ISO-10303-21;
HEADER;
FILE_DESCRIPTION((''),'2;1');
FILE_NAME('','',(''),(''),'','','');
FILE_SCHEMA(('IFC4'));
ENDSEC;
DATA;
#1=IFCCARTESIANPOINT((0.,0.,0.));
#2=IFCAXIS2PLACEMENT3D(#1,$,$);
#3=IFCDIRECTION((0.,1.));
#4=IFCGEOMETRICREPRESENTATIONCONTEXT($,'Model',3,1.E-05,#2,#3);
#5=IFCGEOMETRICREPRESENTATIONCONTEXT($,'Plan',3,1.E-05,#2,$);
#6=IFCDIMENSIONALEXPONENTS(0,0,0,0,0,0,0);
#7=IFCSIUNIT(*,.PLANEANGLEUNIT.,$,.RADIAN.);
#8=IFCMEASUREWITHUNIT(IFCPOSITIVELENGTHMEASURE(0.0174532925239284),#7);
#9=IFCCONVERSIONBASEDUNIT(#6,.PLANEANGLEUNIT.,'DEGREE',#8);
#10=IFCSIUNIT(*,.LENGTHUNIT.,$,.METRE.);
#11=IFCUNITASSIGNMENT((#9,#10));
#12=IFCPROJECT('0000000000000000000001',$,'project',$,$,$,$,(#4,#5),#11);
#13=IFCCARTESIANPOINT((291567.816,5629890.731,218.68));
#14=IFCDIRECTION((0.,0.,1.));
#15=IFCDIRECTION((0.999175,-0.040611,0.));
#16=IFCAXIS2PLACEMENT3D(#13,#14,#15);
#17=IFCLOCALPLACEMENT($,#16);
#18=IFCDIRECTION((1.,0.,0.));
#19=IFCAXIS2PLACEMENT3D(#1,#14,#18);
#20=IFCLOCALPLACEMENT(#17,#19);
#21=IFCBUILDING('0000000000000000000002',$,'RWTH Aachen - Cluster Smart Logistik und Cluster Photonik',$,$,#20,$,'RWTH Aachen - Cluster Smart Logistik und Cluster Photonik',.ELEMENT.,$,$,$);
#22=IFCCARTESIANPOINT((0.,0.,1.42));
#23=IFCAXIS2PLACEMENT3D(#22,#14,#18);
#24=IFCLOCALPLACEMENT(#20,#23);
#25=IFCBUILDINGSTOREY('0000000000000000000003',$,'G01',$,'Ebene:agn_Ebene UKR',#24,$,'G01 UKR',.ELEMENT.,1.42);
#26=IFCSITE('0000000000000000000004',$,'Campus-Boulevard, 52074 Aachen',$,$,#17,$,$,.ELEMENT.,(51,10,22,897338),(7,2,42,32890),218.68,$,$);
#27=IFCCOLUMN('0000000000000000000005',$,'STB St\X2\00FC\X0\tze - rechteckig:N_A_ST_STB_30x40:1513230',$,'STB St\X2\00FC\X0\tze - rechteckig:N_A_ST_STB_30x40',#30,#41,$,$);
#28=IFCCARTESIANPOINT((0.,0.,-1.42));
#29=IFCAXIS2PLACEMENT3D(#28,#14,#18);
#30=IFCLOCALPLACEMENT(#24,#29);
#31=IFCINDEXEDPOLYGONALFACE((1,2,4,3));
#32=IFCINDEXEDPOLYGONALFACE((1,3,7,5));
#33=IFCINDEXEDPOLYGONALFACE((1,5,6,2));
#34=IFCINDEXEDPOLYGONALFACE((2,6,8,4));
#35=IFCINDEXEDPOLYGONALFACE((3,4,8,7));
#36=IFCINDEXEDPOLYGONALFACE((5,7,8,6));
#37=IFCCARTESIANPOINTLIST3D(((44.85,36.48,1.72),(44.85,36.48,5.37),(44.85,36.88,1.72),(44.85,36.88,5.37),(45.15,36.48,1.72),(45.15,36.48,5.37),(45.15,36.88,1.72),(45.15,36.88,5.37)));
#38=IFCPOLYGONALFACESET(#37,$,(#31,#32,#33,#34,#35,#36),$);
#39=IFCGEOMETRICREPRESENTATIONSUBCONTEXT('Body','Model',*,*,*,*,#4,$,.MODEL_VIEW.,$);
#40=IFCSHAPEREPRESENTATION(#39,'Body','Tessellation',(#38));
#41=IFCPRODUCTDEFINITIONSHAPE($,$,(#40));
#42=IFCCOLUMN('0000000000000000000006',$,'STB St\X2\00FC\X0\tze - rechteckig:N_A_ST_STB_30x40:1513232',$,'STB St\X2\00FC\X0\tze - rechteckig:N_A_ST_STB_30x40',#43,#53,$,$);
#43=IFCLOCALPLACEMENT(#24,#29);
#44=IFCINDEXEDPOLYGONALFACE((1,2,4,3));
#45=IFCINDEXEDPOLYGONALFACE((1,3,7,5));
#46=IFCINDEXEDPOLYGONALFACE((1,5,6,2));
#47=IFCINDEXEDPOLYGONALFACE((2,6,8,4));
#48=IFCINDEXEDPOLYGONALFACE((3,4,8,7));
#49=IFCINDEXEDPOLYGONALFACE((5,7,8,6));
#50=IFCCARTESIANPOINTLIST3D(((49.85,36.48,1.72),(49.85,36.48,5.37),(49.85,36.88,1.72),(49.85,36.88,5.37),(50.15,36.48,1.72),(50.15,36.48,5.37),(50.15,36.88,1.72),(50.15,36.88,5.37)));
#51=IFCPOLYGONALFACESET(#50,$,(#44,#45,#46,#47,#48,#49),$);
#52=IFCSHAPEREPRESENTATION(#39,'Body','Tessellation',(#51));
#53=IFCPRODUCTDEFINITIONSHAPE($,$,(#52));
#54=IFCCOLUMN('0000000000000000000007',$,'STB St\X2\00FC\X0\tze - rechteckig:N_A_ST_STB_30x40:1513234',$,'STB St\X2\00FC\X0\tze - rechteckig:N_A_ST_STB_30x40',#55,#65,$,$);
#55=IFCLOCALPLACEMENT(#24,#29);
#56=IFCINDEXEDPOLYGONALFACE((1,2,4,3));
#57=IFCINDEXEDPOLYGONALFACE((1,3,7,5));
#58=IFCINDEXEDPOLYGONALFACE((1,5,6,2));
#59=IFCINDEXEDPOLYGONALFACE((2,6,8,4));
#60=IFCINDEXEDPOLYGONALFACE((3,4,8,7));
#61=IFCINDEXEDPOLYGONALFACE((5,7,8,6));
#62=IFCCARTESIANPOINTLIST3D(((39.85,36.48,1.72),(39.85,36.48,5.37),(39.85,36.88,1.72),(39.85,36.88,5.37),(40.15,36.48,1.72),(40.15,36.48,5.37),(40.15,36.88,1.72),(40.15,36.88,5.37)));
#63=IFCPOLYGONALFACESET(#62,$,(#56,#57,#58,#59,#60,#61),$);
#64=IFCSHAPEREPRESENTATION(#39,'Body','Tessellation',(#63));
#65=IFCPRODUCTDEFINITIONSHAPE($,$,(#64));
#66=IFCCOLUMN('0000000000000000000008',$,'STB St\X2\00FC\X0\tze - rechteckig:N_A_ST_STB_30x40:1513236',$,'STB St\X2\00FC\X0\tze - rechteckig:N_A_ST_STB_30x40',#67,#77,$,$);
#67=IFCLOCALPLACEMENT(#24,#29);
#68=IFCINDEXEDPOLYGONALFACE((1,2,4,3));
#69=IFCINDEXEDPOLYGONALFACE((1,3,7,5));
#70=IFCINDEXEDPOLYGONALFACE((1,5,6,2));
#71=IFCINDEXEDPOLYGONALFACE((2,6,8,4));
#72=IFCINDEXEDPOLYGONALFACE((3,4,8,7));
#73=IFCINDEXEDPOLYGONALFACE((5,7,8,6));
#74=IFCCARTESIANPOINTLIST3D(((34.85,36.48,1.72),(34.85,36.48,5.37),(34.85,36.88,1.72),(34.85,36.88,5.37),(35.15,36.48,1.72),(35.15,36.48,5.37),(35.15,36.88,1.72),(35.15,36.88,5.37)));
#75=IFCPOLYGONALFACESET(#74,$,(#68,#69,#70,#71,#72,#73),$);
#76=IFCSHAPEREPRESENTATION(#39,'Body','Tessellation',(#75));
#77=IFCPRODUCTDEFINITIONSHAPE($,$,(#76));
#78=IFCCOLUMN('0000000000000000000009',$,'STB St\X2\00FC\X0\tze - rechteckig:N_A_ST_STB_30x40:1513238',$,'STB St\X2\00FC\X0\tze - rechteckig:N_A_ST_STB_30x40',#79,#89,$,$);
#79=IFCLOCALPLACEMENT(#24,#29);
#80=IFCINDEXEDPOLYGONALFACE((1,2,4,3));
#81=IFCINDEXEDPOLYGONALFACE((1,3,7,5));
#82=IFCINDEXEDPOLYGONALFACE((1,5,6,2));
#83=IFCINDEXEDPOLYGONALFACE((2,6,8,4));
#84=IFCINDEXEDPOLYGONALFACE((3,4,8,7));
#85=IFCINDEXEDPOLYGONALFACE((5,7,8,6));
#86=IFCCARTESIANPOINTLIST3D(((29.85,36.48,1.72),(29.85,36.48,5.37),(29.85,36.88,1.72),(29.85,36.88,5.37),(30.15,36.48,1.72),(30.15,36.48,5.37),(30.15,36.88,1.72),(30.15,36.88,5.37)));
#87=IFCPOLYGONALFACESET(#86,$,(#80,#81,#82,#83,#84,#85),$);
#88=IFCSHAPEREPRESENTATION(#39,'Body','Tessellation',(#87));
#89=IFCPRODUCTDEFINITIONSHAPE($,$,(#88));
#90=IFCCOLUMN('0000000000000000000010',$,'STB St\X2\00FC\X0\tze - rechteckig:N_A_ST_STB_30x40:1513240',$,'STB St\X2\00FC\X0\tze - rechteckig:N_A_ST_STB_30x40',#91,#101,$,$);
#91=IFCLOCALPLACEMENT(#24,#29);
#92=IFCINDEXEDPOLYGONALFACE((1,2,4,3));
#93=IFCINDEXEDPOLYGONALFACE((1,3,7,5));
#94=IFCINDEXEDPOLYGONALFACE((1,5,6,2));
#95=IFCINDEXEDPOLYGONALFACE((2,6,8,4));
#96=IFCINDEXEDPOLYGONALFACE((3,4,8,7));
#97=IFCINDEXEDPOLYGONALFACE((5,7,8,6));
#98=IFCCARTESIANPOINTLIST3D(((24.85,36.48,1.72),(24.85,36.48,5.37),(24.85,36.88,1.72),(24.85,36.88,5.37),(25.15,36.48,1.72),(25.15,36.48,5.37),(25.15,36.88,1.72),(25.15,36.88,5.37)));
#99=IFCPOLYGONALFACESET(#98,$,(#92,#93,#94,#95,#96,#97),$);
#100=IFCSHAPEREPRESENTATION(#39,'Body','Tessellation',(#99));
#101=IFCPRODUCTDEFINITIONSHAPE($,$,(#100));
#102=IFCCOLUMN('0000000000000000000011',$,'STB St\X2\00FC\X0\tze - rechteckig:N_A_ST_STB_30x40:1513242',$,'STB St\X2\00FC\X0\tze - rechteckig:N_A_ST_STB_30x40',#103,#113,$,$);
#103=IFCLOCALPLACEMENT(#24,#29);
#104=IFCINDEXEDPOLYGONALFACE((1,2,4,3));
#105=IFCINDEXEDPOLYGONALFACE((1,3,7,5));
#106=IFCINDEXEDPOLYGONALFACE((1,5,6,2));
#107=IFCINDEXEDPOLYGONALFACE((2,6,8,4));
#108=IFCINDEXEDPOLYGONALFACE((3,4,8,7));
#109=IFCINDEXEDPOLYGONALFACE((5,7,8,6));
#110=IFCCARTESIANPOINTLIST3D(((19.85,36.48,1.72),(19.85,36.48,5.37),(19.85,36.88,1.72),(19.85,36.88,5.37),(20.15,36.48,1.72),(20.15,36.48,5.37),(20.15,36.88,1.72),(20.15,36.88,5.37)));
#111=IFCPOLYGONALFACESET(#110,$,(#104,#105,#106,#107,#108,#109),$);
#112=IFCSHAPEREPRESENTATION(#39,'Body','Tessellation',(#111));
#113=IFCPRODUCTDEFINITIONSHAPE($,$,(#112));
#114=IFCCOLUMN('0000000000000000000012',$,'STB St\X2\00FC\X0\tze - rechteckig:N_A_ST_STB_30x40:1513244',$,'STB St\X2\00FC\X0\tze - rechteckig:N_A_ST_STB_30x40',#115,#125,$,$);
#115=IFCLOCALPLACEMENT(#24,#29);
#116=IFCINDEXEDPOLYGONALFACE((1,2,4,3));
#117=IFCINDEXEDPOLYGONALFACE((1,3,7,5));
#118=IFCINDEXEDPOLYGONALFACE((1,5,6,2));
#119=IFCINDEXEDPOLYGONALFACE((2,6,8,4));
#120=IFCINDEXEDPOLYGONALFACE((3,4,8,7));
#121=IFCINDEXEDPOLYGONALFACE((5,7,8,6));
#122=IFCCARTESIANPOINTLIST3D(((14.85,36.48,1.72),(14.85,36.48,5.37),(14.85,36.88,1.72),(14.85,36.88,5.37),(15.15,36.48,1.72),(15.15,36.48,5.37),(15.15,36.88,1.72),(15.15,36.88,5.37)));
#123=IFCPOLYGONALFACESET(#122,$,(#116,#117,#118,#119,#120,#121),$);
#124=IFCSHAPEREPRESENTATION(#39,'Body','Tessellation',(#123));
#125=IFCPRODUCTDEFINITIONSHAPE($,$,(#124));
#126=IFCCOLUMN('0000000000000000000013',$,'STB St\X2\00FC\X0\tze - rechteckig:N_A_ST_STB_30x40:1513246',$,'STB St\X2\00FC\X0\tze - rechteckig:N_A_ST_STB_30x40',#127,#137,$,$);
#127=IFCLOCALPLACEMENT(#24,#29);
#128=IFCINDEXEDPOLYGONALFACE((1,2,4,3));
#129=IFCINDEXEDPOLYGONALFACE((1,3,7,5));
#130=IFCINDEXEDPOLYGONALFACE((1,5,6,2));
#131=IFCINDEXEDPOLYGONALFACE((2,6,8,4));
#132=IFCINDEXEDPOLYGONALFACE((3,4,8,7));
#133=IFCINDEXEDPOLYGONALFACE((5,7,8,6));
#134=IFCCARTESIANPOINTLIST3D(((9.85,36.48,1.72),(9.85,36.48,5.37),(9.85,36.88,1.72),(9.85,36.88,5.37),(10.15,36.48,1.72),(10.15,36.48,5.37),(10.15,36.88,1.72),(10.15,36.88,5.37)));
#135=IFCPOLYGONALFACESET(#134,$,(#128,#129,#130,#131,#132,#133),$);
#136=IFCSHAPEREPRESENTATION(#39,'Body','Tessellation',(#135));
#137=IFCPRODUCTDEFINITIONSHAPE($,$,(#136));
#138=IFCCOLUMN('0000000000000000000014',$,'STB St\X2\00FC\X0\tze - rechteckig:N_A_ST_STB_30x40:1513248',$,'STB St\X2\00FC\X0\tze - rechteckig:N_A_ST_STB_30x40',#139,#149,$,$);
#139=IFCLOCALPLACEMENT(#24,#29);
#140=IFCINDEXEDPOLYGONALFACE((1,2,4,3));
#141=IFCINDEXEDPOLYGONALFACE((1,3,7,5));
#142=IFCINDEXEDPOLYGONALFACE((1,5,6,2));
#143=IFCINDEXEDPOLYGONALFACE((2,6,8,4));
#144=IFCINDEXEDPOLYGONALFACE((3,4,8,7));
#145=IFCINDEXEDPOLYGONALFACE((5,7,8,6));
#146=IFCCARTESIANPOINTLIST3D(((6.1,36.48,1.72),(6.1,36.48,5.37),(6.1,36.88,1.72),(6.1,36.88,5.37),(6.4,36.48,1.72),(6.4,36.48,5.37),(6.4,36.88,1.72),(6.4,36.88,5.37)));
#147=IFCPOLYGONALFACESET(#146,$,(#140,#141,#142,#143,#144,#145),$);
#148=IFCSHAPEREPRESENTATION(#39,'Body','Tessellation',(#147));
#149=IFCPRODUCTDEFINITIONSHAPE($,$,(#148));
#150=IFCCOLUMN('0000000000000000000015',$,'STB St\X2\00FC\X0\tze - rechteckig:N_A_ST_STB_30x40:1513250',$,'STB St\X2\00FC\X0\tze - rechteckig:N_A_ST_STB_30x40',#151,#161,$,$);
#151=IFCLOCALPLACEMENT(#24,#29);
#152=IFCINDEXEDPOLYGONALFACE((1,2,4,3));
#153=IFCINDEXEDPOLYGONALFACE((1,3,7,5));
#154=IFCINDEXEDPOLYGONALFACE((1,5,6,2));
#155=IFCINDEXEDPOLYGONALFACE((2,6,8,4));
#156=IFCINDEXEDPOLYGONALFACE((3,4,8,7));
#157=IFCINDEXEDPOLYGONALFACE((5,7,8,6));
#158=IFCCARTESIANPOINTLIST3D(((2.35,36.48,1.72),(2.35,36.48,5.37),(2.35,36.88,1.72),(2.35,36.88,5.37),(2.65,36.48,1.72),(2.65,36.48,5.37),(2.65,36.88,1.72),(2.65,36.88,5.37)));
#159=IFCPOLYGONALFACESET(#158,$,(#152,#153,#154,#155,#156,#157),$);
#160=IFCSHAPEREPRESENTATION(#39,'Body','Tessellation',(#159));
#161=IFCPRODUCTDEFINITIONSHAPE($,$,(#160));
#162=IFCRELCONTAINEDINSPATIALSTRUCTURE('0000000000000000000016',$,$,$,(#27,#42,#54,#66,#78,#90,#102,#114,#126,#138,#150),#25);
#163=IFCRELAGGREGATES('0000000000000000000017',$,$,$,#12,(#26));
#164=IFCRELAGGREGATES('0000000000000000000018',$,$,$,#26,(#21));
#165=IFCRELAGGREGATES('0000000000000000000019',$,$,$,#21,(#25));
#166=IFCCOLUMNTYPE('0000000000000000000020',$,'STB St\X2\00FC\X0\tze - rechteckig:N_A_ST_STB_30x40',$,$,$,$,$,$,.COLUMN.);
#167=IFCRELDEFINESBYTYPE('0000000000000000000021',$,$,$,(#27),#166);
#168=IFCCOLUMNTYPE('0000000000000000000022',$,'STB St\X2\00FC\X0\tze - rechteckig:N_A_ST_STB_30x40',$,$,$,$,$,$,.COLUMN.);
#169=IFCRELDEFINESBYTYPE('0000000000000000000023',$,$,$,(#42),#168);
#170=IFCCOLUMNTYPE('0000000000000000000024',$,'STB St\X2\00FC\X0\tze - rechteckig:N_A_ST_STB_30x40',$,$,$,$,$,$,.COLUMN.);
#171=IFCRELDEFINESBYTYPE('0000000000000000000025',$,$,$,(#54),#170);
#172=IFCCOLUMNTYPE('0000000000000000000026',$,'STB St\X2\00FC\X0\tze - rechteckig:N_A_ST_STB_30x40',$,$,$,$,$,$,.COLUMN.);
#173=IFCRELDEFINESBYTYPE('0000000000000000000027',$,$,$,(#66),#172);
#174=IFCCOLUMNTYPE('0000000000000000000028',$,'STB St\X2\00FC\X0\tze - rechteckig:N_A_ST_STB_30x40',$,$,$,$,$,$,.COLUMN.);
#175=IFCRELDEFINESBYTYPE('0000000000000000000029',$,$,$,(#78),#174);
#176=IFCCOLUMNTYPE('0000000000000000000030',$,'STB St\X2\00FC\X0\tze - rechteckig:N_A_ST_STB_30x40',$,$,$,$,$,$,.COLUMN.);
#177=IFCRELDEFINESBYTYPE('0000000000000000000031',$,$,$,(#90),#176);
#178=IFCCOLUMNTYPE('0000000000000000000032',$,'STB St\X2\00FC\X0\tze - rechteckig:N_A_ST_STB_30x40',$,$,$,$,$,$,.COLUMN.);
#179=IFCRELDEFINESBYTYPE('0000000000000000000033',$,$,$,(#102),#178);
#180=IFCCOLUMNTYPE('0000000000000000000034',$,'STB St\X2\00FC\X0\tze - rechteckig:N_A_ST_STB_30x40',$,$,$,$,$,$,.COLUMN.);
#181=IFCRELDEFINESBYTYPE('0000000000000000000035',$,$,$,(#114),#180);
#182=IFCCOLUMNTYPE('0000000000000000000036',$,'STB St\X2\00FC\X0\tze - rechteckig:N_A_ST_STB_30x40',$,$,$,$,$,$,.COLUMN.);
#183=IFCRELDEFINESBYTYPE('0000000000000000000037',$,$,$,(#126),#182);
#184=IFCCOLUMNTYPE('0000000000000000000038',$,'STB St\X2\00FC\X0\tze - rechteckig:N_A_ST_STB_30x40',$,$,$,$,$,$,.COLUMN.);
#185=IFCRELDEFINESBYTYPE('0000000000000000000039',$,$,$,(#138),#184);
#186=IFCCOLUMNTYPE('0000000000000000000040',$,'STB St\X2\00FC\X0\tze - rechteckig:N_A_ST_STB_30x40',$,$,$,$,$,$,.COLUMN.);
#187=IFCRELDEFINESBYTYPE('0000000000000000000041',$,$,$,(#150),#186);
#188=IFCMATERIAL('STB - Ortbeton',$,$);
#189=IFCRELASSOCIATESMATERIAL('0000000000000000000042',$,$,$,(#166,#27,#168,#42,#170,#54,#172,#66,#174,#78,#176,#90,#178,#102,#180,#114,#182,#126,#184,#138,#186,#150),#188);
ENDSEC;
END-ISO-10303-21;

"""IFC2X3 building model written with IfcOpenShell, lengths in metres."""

from ifc_helpers import new_model, entity, si_unit, converted_unit, direction, frame, frame_2d, origin, origin_with_axes, origin_2d_with_axis, place, context, subcontext, project, spatial, rectangle, extrude, source, transform, mapped, material, type_object, element, save


model = new_model("IFC2X3")

# Units and contexts
model_context = context("Model", 3, precision=1e-05, world=origin(), true_north=direction((0.0, 1.0)))
plan_context = context("Plan", 3, precision=1e-05, world=origin())
body_context = subcontext(model_context, "Body", "Model", "MODEL_VIEW")
ifc_project = project(units=[converted_unit("PLANEANGLEUNIT", "DEGREE", entity("IfcPositiveLengthMeasure", 0.0174532925239284), si_unit("PLANEANGLEUNIT", "RADIAN"), dimensions=[0, 0, 0, 0, 0, 0, 0]), si_unit("LENGTHUNIT", "METRE")], contexts=[model_context, plan_context])

# Site, building, storey
site_placement = place(None, frame((291567.816, 5629890.731, 218.68), z_axis=(0.0, 0.0, 1.0), x_axis=(0.999175, -0.040611, 0.0)))
site = spatial("IfcSite", under=ifc_project, at=site_placement, Name="Campus-Boulevard, 52074 Aachen", CompositionType="ELEMENT", RefLatitude=(51, 10, 22, 897338), RefLongitude=(7, 2, 42, 32890), RefElevation=218.68)
building_placement = place(site_placement, origin_with_axes())
building = spatial("IfcBuilding", under=site, at=building_placement, Name="RWTH Aachen - Cluster Smart Logistik und Cluster Photonik", LongName="RWTH Aachen - Cluster Smart Logistik und Cluster Photonik", CompositionType="ELEMENT")
storey_placement = place(building_placement, frame((0.0, 0.0, 1.42), z_axis=(0.0, 0.0, 1.0), x_axis=(1.0, 0.0, 0.0)))
storey = spatial("IfcBuildingStorey", under=building, at=storey_placement, Name="G01", ObjectType="Ebene:agn_Ebene UKR", LongName="G01 UKR", CompositionType="ELEMENT", Elevation=1.42)

# Columns
ifc_material = material(Name="STB - Ortbeton")
column_type_1 = type_object("IfcColumnType", Name="STB Stütze - rechteckig:N_A_ST_STB_30x40", PredefinedType="COLUMN", material=ifc_material)
shared_shape_1 = source(origin(), body_context, "Body", "SweptSolid", [
    extrude(rectangle(XDim=0.4, YDim=0.3, at=origin_2d_with_axis()), frame((45.0, 36.68, 1.72), z_axis=(0.0, 0.0, 1.0), x_axis=(0.0, -1.0, 0.0)), (0.0, 0.0, 1.0), 3.65),
])
column_1_placement = place(storey_placement, frame((0.0, 0.0, -1.42), z_axis=(0.0, 0.0, 1.0), x_axis=(1.0, 0.0, 0.0)))
element("IfcColumn", 1, at=column_1_placement, inside=storey, type_object=column_type_1, material=ifc_material, Name="STB Stütze - rechteckig:N_A_ST_STB_30x40:1513230", ObjectType="STB Stütze - rechteckig:N_A_ST_STB_30x40", context=body_context, shape_type="MappedRepresentation", body=[
    mapped(shared_shape_1, transform((0.0, 0.0, 0.0), scale=1.0)),
])
column_type_2 = type_object("IfcColumnType", Name="STB Stütze - rechteckig:N_A_ST_STB_30x40", PredefinedType="COLUMN", material=ifc_material)
shared_shape_2 = source(origin(), body_context, "Body", "SweptSolid", [
    extrude(rectangle(XDim=0.4, YDim=0.3, at=origin_2d_with_axis()), frame((50.0, 36.68, 1.72), z_axis=(0.0, 0.0, 1.0), x_axis=(0.0, -1.0, 0.0)), (0.0, 0.0, 1.0), 3.65),
])
column_2_placement = place(storey_placement, frame((0.0, 0.0, -1.42), z_axis=(0.0, 0.0, 1.0), x_axis=(1.0, 0.0, 0.0)))
element("IfcColumn", 2, at=column_2_placement, inside=storey, type_object=column_type_2, material=ifc_material, Name="STB Stütze - rechteckig:N_A_ST_STB_30x40:1513232", ObjectType="STB Stütze - rechteckig:N_A_ST_STB_30x40", context=body_context, shape_type="MappedRepresentation", body=[
    mapped(shared_shape_2, transform((0.0, 0.0, 0.0), scale=1.0)),
])
column_type_3 = type_object("IfcColumnType", Name="STB Stütze - rechteckig:N_A_ST_STB_30x40", PredefinedType="COLUMN", material=ifc_material)
shared_shape_3 = source(origin(), body_context, "Body", "SweptSolid", [
    extrude(rectangle(XDim=0.4, YDim=0.3, at=origin_2d_with_axis()), frame((40.0, 36.68, 1.72), z_axis=(0.0, 0.0, 1.0), x_axis=(0.0, -1.0, 0.0)), (0.0, 0.0, 1.0), 3.65),
])
column_3_placement = place(storey_placement, frame((0.0, 0.0, -1.42), z_axis=(0.0, 0.0, 1.0), x_axis=(1.0, 0.0, 0.0)))
element("IfcColumn", 3, at=column_3_placement, inside=storey, type_object=column_type_3, material=ifc_material, Name="STB Stütze - rechteckig:N_A_ST_STB_30x40:1513234", ObjectType="STB Stütze - rechteckig:N_A_ST_STB_30x40", context=body_context, shape_type="MappedRepresentation", body=[
    mapped(shared_shape_3, transform((0.0, 0.0, 0.0), scale=1.0)),
])
column_type_4 = type_object("IfcColumnType", Name="STB Stütze - rechteckig:N_A_ST_STB_30x40", PredefinedType="COLUMN", material=ifc_material)
shared_shape_4 = source(origin(), body_context, "Body", "SweptSolid", [
    extrude(rectangle(XDim=0.4, YDim=0.3, at=frame_2d((0.0, 0.0), x_axis=(1.0, 0.0))), frame((35.0, 36.68, 1.72), z_axis=(0.0, 0.0, 1.0), x_axis=(0.0, -1.0, 0.0)), (0.0, 0.0, 1.0), 3.65),
])
column_4_placement = place(storey_placement, frame((0.0, 0.0, -1.42), z_axis=(0.0, 0.0, 1.0), x_axis=(1.0, 0.0, 0.0)))
element("IfcColumn", 4, at=column_4_placement, inside=storey, type_object=column_type_4, material=ifc_material, Name="STB Stütze - rechteckig:N_A_ST_STB_30x40:1513236", ObjectType="STB Stütze - rechteckig:N_A_ST_STB_30x40", context=body_context, shape_type="MappedRepresentation", body=[
    mapped(shared_shape_4, transform((0.0, 0.0, 0.0), scale=1.0)),
])
column_type_5 = type_object("IfcColumnType", Name="STB Stütze - rechteckig:N_A_ST_STB_30x40", PredefinedType="COLUMN", material=ifc_material)
shared_shape_5 = source(origin(), body_context, "Body", "SweptSolid", [
    extrude(rectangle(XDim=0.4, YDim=0.3, at=frame_2d((0.0, 0.0), x_axis=(1.0, 0.0))), frame((30.0, 36.68, 1.72), z_axis=(0.0, 0.0, 1.0), x_axis=(0.0, -1.0, 0.0)), (0.0, 0.0, 1.0), 3.65),
])
column_5_placement = place(storey_placement, frame((0.0, 0.0, -1.42), z_axis=(0.0, 0.0, 1.0), x_axis=(1.0, 0.0, 0.0)))
element("IfcColumn", 5, at=column_5_placement, inside=storey, type_object=column_type_5, material=ifc_material, Name="STB Stütze - rechteckig:N_A_ST_STB_30x40:1513238", ObjectType="STB Stütze - rechteckig:N_A_ST_STB_30x40", context=body_context, shape_type="MappedRepresentation", body=[
    mapped(shared_shape_5, transform((0.0, 0.0, 0.0), scale=1.0)),
])
column_type_6 = type_object("IfcColumnType", Name="STB Stütze - rechteckig:N_A_ST_STB_30x40", PredefinedType="COLUMN", material=ifc_material)
shared_shape_6 = source(origin(), body_context, "Body", "SweptSolid", [
    extrude(rectangle(XDim=0.4, YDim=0.3, at=origin_2d_with_axis()), frame((25.0, 36.68, 1.72), z_axis=(0.0, 0.0, 1.0), x_axis=(0.0, -1.0, 0.0)), (0.0, 0.0, 1.0), 3.65),
])
column_6_placement = place(storey_placement, frame((0.0, 0.0, -1.42), z_axis=(0.0, 0.0, 1.0), x_axis=(1.0, 0.0, 0.0)))
element("IfcColumn", 6, at=column_6_placement, inside=storey, type_object=column_type_6, material=ifc_material, Name="STB Stütze - rechteckig:N_A_ST_STB_30x40:1513240", ObjectType="STB Stütze - rechteckig:N_A_ST_STB_30x40", context=body_context, shape_type="MappedRepresentation", body=[
    mapped(shared_shape_6, transform((0.0, 0.0, 0.0), scale=1.0)),
])
column_type_7 = type_object("IfcColumnType", Name="STB Stütze - rechteckig:N_A_ST_STB_30x40", PredefinedType="COLUMN", material=ifc_material)
shared_shape_7 = source(origin(), body_context, "Body", "SweptSolid", [
    extrude(rectangle(XDim=0.4, YDim=0.3, at=origin_2d_with_axis()), frame((20.0, 36.68, 1.72), z_axis=(0.0, 0.0, 1.0), x_axis=(0.0, -1.0, 0.0)), (0.0, 0.0, 1.0), 3.65),
])
column_7_placement = place(storey_placement, frame((0.0, 0.0, -1.42), z_axis=(0.0, 0.0, 1.0), x_axis=(1.0, 0.0, 0.0)))
element("IfcColumn", 7, at=column_7_placement, inside=storey, type_object=column_type_7, material=ifc_material, Name="STB Stütze - rechteckig:N_A_ST_STB_30x40:1513242", ObjectType="STB Stütze - rechteckig:N_A_ST_STB_30x40", context=body_context, shape_type="MappedRepresentation", body=[
    mapped(shared_shape_7, transform((0.0, 0.0, 0.0), scale=1.0)),
])
column_type_8 = type_object("IfcColumnType", Name="STB Stütze - rechteckig:N_A_ST_STB_30x40", PredefinedType="COLUMN", material=ifc_material)
shared_shape_8 = source(origin(), body_context, "Body", "SweptSolid", [
    extrude(rectangle(XDim=0.4, YDim=0.3, at=origin_2d_with_axis()), frame((15.0, 36.68, 1.72), z_axis=(0.0, 0.0, 1.0), x_axis=(0.0, -1.0, 0.0)), (0.0, 0.0, 1.0), 3.65),
])
column_8_placement = place(storey_placement, frame((0.0, 0.0, -1.42), z_axis=(0.0, 0.0, 1.0), x_axis=(1.0, 0.0, 0.0)))
element("IfcColumn", 8, at=column_8_placement, inside=storey, type_object=column_type_8, material=ifc_material, Name="STB Stütze - rechteckig:N_A_ST_STB_30x40:1513244", ObjectType="STB Stütze - rechteckig:N_A_ST_STB_30x40", context=body_context, shape_type="MappedRepresentation", body=[
    mapped(shared_shape_8, transform((0.0, 0.0, 0.0), scale=1.0)),
])
column_type_9 = type_object("IfcColumnType", Name="STB Stütze - rechteckig:N_A_ST_STB_30x40", PredefinedType="COLUMN", material=ifc_material)
shared_shape_9 = source(origin(), body_context, "Body", "SweptSolid", [
    extrude(rectangle(XDim=0.4, YDim=0.3, at=frame_2d((0.0, 0.0), x_axis=(1.0, 0.0))), frame((10.0, 36.68, 1.72), z_axis=(0.0, 0.0, 1.0), x_axis=(0.0, -1.0, 0.0)), (0.0, 0.0, 1.0), 3.65),
])
column_9_placement = place(storey_placement, frame((0.0, 0.0, -1.42), z_axis=(0.0, 0.0, 1.0), x_axis=(1.0, 0.0, 0.0)))
element("IfcColumn", 9, at=column_9_placement, inside=storey, type_object=column_type_9, material=ifc_material, Name="STB Stütze - rechteckig:N_A_ST_STB_30x40:1513246", ObjectType="STB Stütze - rechteckig:N_A_ST_STB_30x40", context=body_context, shape_type="MappedRepresentation", body=[
    mapped(shared_shape_9, transform((0.0, 0.0, 0.0), scale=1.0)),
])
column_type_10 = type_object("IfcColumnType", Name="STB Stütze - rechteckig:N_A_ST_STB_30x40", PredefinedType="COLUMN", material=ifc_material)
shared_shape_10 = source(origin(), body_context, "Body", "SweptSolid", [
    extrude(rectangle(XDim=0.4, YDim=0.3, at=frame_2d((0.0, 0.0), x_axis=(1.0, 0.0))), frame((6.25, 36.68, 1.72), z_axis=(0.0, 0.0, 1.0), x_axis=(0.0, -1.0, 0.0)), (0.0, 0.0, 1.0), 3.65),
])
column_10_placement = place(storey_placement, frame((0.0, 0.0, -1.42), z_axis=(0.0, 0.0, 1.0), x_axis=(1.0, 0.0, 0.0)))
element("IfcColumn", 10, at=column_10_placement, inside=storey, type_object=column_type_10, material=ifc_material, Name="STB Stütze - rechteckig:N_A_ST_STB_30x40:1513248", ObjectType="STB Stütze - rechteckig:N_A_ST_STB_30x40", context=body_context, shape_type="MappedRepresentation", body=[
    mapped(shared_shape_10, transform((0.0, 0.0, 0.0), scale=1.0)),
])
column_type_11 = type_object("IfcColumnType", Name="STB Stütze - rechteckig:N_A_ST_STB_30x40", PredefinedType="COLUMN", material=ifc_material)
shared_shape_11 = source(origin(), body_context, "Body", "SweptSolid", [
    extrude(rectangle(XDim=0.4, YDim=0.3, at=frame_2d((0.0, 0.0), x_axis=(1.0, 0.0))), frame((2.5, 36.68, 1.72), z_axis=(0.0, 0.0, 1.0), x_axis=(0.0, -1.0, 0.0)), (0.0, 0.0, 1.0), 3.65),
])
column_11_placement = place(storey_placement, frame((0.0, 0.0, -1.42), z_axis=(0.0, 0.0, 1.0), x_axis=(1.0, 0.0, 0.0)))
element("IfcColumn", 11, at=column_11_placement, inside=storey, type_object=column_type_11, material=ifc_material, Name="STB Stütze - rechteckig:N_A_ST_STB_30x40:1513250", ObjectType="STB Stütze - rechteckig:N_A_ST_STB_30x40", context=body_context, shape_type="MappedRepresentation", body=[
    mapped(shared_shape_11, transform((0.0, 0.0, 0.0), scale=1.0)),
])

save(model, "model.ifc")
